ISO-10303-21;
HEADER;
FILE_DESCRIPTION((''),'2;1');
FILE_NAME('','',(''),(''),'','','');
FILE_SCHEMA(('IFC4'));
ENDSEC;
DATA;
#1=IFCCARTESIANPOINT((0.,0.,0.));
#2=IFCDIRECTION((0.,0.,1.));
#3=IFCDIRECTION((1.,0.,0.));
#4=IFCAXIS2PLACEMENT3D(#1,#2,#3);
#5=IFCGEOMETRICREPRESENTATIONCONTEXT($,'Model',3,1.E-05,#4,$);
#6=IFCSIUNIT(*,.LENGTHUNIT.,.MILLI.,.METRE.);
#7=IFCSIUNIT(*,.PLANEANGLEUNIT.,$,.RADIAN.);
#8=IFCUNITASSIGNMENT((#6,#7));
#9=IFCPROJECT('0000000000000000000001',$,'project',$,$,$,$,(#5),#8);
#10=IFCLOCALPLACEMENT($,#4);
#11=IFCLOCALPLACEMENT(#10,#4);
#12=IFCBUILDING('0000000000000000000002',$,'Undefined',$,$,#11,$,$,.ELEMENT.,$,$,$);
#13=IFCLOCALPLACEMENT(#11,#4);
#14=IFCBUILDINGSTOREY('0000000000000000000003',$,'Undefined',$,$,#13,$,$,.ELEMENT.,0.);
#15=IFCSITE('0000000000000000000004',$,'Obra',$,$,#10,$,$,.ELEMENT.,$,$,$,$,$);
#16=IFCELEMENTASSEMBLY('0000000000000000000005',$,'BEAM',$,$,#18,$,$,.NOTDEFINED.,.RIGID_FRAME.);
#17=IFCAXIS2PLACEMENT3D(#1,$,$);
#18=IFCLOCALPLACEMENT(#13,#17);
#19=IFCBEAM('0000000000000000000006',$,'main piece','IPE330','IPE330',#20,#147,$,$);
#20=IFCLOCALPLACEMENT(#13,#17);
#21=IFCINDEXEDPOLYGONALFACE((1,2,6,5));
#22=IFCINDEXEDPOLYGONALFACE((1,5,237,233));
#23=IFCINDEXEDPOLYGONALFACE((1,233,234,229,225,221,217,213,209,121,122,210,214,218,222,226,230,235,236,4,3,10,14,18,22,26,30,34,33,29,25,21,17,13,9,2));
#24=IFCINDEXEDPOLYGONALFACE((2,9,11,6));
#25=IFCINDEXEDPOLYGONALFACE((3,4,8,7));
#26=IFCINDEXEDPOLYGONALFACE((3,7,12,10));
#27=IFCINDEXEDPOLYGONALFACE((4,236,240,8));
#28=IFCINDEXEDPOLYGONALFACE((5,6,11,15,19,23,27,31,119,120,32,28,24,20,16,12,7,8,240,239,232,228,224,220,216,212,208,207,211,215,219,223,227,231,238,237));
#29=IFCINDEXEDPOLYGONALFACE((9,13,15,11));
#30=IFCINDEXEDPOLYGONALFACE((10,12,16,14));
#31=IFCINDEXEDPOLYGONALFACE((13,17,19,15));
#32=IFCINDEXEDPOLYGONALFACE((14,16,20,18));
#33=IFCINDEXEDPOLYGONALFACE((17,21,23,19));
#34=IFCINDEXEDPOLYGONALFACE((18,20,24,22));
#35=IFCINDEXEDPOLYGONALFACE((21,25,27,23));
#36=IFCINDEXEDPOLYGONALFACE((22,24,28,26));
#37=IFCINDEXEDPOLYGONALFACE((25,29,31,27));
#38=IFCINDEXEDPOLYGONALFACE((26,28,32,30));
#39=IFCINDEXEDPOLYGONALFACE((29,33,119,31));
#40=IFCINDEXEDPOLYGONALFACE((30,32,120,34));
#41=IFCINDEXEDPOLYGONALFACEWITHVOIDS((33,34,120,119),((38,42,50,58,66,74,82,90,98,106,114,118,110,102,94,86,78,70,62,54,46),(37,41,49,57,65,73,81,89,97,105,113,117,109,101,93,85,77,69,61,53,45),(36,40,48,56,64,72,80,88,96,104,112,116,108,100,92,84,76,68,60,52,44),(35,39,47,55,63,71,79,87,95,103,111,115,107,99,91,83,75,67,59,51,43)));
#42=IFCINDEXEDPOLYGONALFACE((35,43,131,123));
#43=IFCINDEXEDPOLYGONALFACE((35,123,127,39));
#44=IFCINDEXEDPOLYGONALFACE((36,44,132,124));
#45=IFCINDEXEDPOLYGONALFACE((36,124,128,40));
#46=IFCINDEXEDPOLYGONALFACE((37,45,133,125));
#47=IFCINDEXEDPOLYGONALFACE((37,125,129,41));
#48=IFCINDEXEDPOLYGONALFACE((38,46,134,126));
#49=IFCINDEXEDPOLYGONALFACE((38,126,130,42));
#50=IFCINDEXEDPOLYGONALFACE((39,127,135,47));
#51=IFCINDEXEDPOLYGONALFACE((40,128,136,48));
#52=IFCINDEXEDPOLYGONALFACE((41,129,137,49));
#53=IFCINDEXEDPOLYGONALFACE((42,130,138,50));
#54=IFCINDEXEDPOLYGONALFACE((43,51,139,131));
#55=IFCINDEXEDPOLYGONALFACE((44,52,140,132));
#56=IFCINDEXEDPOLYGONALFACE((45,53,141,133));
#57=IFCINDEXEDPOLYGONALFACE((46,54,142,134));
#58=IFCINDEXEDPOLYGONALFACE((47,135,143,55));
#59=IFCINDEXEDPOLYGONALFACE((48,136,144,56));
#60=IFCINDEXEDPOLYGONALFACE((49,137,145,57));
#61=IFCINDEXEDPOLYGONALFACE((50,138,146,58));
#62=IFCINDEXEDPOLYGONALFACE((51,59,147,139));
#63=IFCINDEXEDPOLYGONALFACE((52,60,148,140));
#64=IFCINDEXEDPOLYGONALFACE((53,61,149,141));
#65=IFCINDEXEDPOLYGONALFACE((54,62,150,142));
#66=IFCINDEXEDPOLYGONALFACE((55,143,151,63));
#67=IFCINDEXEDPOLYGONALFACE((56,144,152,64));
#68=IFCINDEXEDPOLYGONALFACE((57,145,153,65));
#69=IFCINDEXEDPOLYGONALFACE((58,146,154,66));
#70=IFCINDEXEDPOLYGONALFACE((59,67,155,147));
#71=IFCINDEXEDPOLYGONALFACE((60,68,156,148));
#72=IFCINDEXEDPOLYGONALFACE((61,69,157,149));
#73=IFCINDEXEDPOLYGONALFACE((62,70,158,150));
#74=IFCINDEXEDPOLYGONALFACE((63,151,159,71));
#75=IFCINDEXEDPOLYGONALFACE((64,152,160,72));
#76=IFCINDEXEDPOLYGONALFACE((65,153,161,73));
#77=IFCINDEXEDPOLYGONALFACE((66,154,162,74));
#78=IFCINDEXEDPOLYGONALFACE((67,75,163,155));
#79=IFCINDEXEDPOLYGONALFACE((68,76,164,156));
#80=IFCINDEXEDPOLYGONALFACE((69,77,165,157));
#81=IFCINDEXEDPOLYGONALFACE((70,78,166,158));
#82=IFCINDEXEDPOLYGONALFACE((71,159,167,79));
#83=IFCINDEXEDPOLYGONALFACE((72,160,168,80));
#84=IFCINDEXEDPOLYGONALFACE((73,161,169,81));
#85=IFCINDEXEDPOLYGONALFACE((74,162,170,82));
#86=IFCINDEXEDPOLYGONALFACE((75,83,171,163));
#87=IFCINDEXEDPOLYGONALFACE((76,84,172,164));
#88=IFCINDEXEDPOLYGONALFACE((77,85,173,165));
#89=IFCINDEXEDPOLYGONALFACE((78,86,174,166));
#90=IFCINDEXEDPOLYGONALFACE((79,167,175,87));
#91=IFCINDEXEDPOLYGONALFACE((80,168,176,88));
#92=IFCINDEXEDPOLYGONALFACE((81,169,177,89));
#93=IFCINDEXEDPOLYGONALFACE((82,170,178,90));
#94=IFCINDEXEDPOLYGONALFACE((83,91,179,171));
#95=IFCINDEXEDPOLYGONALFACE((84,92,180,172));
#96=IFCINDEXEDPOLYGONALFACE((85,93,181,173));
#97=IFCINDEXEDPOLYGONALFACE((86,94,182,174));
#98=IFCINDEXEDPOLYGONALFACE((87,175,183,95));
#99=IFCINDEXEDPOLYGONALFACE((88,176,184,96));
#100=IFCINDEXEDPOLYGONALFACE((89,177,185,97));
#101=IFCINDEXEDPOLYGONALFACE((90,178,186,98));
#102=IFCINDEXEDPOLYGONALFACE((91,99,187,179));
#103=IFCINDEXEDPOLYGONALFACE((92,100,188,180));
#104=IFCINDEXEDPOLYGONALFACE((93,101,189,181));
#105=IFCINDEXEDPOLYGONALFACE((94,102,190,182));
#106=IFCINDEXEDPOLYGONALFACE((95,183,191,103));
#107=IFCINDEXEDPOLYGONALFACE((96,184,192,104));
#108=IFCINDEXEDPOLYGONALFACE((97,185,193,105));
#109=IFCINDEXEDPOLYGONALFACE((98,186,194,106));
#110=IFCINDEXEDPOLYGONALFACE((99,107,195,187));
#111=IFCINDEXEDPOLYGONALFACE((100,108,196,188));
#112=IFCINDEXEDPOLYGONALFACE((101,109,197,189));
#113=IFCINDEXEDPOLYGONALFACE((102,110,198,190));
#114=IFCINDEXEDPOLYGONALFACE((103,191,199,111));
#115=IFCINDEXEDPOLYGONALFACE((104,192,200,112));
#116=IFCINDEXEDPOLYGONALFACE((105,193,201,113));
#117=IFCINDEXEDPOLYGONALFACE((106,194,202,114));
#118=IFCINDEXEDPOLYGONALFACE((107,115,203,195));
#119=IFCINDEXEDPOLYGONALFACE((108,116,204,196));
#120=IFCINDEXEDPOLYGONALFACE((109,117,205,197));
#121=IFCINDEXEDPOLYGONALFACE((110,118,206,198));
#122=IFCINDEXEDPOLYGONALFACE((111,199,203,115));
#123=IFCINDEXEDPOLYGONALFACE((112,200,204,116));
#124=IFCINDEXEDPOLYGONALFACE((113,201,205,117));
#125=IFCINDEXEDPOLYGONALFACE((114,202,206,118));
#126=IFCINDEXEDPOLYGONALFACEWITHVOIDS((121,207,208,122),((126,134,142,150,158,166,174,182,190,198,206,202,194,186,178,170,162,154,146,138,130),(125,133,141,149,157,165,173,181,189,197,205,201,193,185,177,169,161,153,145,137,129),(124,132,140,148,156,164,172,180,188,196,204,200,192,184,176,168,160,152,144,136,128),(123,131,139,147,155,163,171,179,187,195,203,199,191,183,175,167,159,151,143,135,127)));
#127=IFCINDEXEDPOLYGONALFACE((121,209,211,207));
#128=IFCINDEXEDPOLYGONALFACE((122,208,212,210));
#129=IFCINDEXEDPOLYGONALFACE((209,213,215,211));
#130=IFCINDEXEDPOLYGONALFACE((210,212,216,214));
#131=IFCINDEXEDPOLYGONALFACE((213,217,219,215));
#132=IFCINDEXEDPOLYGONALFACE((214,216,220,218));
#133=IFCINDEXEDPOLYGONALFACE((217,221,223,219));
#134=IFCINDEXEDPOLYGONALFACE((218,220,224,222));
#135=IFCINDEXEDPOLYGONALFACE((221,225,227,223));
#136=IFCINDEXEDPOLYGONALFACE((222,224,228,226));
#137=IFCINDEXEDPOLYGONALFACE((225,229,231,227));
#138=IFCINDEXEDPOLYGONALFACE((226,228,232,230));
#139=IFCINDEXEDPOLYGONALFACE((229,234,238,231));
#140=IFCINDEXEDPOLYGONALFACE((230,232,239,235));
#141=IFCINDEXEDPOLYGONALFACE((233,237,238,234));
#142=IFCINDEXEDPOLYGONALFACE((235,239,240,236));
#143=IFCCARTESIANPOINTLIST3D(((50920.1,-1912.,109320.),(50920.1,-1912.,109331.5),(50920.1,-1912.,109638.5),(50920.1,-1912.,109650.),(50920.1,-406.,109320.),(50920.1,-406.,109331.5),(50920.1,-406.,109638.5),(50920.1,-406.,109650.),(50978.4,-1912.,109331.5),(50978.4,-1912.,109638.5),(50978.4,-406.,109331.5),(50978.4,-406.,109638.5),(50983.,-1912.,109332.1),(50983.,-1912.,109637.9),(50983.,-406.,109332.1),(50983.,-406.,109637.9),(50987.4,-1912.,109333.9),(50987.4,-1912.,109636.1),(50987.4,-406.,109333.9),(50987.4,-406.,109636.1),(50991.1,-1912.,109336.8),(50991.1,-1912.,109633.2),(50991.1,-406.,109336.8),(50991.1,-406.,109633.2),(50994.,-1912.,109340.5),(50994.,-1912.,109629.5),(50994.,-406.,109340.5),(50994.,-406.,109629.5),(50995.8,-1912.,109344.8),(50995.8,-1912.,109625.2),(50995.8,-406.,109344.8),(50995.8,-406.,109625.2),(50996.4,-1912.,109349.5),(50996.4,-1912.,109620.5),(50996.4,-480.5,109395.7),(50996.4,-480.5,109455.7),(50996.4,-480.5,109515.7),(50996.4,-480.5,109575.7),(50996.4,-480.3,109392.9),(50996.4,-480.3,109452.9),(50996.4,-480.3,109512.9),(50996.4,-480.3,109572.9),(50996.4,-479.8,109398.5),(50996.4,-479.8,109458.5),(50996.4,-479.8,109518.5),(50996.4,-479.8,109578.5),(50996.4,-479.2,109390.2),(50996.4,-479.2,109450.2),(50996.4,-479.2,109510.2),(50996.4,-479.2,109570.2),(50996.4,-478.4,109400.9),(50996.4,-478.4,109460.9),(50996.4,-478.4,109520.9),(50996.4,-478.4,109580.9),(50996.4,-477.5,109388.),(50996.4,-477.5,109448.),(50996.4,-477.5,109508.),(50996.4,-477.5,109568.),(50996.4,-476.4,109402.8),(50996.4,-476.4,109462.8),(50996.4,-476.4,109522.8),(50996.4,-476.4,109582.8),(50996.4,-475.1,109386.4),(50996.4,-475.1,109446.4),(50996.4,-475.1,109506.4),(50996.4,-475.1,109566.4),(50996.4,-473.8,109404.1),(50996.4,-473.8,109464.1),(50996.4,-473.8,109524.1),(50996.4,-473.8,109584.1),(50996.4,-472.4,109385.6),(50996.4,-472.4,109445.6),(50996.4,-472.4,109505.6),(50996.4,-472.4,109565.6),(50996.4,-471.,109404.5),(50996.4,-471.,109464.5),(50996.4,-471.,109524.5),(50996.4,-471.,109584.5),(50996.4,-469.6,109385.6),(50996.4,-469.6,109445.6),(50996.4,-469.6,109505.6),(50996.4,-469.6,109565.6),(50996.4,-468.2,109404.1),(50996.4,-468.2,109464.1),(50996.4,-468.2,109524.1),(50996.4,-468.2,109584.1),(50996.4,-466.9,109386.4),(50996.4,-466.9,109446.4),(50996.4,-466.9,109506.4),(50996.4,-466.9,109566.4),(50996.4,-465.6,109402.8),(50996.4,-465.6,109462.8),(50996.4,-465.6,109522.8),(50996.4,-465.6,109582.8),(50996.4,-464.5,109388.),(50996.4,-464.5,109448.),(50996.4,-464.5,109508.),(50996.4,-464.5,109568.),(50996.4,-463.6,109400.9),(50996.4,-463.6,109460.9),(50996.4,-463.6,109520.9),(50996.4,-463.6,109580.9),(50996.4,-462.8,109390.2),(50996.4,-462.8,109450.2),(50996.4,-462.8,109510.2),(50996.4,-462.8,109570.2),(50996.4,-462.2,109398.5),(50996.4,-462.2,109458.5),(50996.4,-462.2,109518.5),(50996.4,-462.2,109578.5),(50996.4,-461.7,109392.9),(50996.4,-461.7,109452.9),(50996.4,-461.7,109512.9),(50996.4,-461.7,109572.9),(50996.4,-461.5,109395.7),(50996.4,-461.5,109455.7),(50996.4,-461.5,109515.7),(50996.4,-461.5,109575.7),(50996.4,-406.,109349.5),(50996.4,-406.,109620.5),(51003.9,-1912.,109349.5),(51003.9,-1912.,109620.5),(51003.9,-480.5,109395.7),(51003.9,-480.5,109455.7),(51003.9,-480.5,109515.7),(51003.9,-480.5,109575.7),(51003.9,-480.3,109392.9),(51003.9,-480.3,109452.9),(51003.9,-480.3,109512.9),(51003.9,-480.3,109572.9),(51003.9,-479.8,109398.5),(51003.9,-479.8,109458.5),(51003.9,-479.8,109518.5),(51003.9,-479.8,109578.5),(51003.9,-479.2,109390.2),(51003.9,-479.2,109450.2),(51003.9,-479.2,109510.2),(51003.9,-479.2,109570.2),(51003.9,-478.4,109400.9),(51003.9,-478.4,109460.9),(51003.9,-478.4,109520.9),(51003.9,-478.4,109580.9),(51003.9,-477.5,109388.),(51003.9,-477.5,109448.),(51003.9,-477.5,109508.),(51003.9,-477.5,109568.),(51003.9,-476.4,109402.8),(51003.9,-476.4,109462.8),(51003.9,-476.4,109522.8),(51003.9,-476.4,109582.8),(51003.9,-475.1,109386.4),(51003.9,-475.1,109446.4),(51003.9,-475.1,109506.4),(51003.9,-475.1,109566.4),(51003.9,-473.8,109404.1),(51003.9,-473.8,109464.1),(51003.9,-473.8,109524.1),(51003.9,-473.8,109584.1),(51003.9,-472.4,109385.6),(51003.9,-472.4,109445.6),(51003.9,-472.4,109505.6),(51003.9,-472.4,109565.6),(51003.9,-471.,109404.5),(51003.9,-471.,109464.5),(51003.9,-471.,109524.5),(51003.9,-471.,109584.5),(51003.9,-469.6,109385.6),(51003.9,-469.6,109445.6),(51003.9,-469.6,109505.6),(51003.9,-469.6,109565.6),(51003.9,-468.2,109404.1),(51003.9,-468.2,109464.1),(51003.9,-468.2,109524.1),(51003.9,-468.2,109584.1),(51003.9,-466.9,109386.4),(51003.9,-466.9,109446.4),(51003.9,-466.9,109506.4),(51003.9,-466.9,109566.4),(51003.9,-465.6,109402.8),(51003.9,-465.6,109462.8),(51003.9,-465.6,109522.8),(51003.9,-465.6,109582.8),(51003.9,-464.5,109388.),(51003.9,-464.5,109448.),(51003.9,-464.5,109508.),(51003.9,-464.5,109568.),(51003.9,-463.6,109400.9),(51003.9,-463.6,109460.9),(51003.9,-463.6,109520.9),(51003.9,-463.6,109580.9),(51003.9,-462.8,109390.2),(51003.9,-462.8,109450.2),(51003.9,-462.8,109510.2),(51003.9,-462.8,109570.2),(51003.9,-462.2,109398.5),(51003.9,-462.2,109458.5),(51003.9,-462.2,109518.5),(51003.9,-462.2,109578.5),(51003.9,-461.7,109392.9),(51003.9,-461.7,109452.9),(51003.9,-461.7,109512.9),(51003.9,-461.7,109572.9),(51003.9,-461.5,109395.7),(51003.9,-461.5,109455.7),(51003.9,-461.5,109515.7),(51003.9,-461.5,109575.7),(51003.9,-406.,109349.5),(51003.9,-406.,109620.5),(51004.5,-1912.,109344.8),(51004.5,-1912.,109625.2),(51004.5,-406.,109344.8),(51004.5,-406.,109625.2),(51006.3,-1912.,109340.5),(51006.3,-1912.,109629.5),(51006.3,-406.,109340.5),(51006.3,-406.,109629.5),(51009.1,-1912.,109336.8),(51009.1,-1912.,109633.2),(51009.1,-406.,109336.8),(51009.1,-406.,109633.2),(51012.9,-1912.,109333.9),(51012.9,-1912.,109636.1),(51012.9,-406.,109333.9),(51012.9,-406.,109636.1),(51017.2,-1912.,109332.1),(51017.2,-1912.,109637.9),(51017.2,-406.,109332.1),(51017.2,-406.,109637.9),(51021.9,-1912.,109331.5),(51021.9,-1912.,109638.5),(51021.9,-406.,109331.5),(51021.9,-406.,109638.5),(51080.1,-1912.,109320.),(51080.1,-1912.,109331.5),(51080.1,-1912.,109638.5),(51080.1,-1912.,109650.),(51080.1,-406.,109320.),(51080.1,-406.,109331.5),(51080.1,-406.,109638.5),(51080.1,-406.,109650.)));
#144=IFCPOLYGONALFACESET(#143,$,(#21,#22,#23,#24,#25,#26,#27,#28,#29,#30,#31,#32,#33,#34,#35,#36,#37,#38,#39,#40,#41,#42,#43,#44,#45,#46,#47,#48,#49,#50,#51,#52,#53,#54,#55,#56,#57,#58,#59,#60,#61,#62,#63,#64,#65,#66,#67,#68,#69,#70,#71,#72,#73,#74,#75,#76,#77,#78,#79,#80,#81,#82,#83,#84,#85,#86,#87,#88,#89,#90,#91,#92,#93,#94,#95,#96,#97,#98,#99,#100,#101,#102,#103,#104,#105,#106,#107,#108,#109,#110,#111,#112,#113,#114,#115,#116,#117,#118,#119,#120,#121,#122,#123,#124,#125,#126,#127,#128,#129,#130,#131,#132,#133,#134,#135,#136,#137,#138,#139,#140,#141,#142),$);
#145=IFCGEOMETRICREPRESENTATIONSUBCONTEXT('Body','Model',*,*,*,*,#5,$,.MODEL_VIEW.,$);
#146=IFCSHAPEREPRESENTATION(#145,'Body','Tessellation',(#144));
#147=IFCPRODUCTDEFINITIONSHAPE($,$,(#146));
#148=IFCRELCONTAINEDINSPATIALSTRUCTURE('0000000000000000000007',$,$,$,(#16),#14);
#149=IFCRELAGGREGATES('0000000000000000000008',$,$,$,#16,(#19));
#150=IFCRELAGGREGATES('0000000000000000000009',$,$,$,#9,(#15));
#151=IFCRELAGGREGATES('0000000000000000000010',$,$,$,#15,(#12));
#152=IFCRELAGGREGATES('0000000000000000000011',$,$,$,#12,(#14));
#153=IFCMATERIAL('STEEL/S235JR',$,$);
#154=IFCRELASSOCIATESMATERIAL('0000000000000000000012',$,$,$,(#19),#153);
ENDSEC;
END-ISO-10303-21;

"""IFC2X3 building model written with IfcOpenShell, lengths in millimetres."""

from ifc_helpers import new_model, si_unit, frame, origin_with_axes, origin_2d_with_axis, place, context, subcontext, project, spatial, circle, i_section, extrude, clip, halfspace, source, transform, mapped, material, element, aggregate, save


model = new_model("IFC2X3")

# Units and contexts
model_context = context("Model", 3, precision=1e-05, world=origin_with_axes())
body_context = subcontext(model_context, "Body", "Model", "MODEL_VIEW")
ifc_project = project(units=[si_unit("LENGTHUNIT", "METRE", prefix="MILLI"), si_unit("PLANEANGLEUNIT", "RADIAN")], contexts=[model_context])

# Site, building, storey
site_placement = place(None, origin_with_axes())
site = spatial("IfcSite", under=ifc_project, at=site_placement, Name="Obra", CompositionType="ELEMENT")
building_placement = place(site_placement, origin_with_axes())
building = spatial("IfcBuilding", under=site, at=building_placement, Name="Undefined", CompositionType="ELEMENT")
storey_placement = place(building_placement, origin_with_axes())
storey = spatial("IfcBuildingStorey", under=building, at=storey_placement, Name="Undefined", CompositionType="ELEMENT", Elevation=0.0)

# Element assembly, beam, opening
ifc_material_1 = material(Name="STEEL/S235JR")
shared_shape_1 = source(origin_with_axes(), body_context, "Body", "SweptSolid", [
    extrude(circle(Radius=9.5, at=origin_2d_with_axis()), frame((0.0, -3.9, 0.0), z_axis=(0.0, 1.0, 0.0), x_axis=(1.0, 0.0, 0.0)), (0.0, 0.0, 1.0), 7.7),
])
assembly_1_placement = place(storey_placement, origin_with_axes())
assembly_1 = element("IfcElementAssembly", 1, at=assembly_1_placement, inside=storey, Name="BEAM", AssemblyPlace="NOTDEFINED", PredefinedType="RIGID_FRAME")
beam_1_placement = place(assembly_1_placement, frame((51000.1, -1912.0, 109485.0), z_axis=(0.0, 0.0, 1.0), x_axis=(0.0, 1.0, 0.0)))
beam_1 = element("IfcBeam", 2, at=beam_1_placement, material=ifc_material_1, Name="main piece", Description="IPE330", ObjectType="IPE330", context=body_context, shape_type="Clipping", body=[
    clip(extrude(i_section(OverallWidth=160.0, OverallDepth=330.0, WebThickness=7.5, FlangeThickness=11.5, FilletRadius=18.0, at=origin_2d_with_axis()), frame((1506.0, 0.0, 0.0), z_axis=(-1.0, 0.0, 0.0), x_axis=(0.0, -1.0, 0.0)), (0.0, 0.0, 1.0), 1506.0), halfspace(frame((1506.0, 0.0, -220.0), z_axis=(-1.0, 0.0, 0.0), x_axis=(0.0, 1.0, 0.0)), True)),
])
opening_1_placement = place(assembly_1_placement, frame((51000.1, -471.0, 109395.0), z_axis=(0.0, 1.0, 0.0), x_axis=(0.0, 0.0, 1.0)))
element("IfcOpeningElement", 3, at=opening_1_placement, cuts=beam_1, ObjectType="Opening", context=body_context, shape_type="MappedRepresentation", body=[
    mapped(shared_shape_1, transform((0.0, 0.0, 0.0))),
    mapped(shared_shape_1, transform((60.0, 0.0, 0.0))),
    mapped(shared_shape_1, transform((120.0, 0.0, 0.0))),
    mapped(shared_shape_1, transform((180.0, 0.0, 0.0))),
])
aggregate(assembly_1, [beam_1])

save(model, "model.ifc")
